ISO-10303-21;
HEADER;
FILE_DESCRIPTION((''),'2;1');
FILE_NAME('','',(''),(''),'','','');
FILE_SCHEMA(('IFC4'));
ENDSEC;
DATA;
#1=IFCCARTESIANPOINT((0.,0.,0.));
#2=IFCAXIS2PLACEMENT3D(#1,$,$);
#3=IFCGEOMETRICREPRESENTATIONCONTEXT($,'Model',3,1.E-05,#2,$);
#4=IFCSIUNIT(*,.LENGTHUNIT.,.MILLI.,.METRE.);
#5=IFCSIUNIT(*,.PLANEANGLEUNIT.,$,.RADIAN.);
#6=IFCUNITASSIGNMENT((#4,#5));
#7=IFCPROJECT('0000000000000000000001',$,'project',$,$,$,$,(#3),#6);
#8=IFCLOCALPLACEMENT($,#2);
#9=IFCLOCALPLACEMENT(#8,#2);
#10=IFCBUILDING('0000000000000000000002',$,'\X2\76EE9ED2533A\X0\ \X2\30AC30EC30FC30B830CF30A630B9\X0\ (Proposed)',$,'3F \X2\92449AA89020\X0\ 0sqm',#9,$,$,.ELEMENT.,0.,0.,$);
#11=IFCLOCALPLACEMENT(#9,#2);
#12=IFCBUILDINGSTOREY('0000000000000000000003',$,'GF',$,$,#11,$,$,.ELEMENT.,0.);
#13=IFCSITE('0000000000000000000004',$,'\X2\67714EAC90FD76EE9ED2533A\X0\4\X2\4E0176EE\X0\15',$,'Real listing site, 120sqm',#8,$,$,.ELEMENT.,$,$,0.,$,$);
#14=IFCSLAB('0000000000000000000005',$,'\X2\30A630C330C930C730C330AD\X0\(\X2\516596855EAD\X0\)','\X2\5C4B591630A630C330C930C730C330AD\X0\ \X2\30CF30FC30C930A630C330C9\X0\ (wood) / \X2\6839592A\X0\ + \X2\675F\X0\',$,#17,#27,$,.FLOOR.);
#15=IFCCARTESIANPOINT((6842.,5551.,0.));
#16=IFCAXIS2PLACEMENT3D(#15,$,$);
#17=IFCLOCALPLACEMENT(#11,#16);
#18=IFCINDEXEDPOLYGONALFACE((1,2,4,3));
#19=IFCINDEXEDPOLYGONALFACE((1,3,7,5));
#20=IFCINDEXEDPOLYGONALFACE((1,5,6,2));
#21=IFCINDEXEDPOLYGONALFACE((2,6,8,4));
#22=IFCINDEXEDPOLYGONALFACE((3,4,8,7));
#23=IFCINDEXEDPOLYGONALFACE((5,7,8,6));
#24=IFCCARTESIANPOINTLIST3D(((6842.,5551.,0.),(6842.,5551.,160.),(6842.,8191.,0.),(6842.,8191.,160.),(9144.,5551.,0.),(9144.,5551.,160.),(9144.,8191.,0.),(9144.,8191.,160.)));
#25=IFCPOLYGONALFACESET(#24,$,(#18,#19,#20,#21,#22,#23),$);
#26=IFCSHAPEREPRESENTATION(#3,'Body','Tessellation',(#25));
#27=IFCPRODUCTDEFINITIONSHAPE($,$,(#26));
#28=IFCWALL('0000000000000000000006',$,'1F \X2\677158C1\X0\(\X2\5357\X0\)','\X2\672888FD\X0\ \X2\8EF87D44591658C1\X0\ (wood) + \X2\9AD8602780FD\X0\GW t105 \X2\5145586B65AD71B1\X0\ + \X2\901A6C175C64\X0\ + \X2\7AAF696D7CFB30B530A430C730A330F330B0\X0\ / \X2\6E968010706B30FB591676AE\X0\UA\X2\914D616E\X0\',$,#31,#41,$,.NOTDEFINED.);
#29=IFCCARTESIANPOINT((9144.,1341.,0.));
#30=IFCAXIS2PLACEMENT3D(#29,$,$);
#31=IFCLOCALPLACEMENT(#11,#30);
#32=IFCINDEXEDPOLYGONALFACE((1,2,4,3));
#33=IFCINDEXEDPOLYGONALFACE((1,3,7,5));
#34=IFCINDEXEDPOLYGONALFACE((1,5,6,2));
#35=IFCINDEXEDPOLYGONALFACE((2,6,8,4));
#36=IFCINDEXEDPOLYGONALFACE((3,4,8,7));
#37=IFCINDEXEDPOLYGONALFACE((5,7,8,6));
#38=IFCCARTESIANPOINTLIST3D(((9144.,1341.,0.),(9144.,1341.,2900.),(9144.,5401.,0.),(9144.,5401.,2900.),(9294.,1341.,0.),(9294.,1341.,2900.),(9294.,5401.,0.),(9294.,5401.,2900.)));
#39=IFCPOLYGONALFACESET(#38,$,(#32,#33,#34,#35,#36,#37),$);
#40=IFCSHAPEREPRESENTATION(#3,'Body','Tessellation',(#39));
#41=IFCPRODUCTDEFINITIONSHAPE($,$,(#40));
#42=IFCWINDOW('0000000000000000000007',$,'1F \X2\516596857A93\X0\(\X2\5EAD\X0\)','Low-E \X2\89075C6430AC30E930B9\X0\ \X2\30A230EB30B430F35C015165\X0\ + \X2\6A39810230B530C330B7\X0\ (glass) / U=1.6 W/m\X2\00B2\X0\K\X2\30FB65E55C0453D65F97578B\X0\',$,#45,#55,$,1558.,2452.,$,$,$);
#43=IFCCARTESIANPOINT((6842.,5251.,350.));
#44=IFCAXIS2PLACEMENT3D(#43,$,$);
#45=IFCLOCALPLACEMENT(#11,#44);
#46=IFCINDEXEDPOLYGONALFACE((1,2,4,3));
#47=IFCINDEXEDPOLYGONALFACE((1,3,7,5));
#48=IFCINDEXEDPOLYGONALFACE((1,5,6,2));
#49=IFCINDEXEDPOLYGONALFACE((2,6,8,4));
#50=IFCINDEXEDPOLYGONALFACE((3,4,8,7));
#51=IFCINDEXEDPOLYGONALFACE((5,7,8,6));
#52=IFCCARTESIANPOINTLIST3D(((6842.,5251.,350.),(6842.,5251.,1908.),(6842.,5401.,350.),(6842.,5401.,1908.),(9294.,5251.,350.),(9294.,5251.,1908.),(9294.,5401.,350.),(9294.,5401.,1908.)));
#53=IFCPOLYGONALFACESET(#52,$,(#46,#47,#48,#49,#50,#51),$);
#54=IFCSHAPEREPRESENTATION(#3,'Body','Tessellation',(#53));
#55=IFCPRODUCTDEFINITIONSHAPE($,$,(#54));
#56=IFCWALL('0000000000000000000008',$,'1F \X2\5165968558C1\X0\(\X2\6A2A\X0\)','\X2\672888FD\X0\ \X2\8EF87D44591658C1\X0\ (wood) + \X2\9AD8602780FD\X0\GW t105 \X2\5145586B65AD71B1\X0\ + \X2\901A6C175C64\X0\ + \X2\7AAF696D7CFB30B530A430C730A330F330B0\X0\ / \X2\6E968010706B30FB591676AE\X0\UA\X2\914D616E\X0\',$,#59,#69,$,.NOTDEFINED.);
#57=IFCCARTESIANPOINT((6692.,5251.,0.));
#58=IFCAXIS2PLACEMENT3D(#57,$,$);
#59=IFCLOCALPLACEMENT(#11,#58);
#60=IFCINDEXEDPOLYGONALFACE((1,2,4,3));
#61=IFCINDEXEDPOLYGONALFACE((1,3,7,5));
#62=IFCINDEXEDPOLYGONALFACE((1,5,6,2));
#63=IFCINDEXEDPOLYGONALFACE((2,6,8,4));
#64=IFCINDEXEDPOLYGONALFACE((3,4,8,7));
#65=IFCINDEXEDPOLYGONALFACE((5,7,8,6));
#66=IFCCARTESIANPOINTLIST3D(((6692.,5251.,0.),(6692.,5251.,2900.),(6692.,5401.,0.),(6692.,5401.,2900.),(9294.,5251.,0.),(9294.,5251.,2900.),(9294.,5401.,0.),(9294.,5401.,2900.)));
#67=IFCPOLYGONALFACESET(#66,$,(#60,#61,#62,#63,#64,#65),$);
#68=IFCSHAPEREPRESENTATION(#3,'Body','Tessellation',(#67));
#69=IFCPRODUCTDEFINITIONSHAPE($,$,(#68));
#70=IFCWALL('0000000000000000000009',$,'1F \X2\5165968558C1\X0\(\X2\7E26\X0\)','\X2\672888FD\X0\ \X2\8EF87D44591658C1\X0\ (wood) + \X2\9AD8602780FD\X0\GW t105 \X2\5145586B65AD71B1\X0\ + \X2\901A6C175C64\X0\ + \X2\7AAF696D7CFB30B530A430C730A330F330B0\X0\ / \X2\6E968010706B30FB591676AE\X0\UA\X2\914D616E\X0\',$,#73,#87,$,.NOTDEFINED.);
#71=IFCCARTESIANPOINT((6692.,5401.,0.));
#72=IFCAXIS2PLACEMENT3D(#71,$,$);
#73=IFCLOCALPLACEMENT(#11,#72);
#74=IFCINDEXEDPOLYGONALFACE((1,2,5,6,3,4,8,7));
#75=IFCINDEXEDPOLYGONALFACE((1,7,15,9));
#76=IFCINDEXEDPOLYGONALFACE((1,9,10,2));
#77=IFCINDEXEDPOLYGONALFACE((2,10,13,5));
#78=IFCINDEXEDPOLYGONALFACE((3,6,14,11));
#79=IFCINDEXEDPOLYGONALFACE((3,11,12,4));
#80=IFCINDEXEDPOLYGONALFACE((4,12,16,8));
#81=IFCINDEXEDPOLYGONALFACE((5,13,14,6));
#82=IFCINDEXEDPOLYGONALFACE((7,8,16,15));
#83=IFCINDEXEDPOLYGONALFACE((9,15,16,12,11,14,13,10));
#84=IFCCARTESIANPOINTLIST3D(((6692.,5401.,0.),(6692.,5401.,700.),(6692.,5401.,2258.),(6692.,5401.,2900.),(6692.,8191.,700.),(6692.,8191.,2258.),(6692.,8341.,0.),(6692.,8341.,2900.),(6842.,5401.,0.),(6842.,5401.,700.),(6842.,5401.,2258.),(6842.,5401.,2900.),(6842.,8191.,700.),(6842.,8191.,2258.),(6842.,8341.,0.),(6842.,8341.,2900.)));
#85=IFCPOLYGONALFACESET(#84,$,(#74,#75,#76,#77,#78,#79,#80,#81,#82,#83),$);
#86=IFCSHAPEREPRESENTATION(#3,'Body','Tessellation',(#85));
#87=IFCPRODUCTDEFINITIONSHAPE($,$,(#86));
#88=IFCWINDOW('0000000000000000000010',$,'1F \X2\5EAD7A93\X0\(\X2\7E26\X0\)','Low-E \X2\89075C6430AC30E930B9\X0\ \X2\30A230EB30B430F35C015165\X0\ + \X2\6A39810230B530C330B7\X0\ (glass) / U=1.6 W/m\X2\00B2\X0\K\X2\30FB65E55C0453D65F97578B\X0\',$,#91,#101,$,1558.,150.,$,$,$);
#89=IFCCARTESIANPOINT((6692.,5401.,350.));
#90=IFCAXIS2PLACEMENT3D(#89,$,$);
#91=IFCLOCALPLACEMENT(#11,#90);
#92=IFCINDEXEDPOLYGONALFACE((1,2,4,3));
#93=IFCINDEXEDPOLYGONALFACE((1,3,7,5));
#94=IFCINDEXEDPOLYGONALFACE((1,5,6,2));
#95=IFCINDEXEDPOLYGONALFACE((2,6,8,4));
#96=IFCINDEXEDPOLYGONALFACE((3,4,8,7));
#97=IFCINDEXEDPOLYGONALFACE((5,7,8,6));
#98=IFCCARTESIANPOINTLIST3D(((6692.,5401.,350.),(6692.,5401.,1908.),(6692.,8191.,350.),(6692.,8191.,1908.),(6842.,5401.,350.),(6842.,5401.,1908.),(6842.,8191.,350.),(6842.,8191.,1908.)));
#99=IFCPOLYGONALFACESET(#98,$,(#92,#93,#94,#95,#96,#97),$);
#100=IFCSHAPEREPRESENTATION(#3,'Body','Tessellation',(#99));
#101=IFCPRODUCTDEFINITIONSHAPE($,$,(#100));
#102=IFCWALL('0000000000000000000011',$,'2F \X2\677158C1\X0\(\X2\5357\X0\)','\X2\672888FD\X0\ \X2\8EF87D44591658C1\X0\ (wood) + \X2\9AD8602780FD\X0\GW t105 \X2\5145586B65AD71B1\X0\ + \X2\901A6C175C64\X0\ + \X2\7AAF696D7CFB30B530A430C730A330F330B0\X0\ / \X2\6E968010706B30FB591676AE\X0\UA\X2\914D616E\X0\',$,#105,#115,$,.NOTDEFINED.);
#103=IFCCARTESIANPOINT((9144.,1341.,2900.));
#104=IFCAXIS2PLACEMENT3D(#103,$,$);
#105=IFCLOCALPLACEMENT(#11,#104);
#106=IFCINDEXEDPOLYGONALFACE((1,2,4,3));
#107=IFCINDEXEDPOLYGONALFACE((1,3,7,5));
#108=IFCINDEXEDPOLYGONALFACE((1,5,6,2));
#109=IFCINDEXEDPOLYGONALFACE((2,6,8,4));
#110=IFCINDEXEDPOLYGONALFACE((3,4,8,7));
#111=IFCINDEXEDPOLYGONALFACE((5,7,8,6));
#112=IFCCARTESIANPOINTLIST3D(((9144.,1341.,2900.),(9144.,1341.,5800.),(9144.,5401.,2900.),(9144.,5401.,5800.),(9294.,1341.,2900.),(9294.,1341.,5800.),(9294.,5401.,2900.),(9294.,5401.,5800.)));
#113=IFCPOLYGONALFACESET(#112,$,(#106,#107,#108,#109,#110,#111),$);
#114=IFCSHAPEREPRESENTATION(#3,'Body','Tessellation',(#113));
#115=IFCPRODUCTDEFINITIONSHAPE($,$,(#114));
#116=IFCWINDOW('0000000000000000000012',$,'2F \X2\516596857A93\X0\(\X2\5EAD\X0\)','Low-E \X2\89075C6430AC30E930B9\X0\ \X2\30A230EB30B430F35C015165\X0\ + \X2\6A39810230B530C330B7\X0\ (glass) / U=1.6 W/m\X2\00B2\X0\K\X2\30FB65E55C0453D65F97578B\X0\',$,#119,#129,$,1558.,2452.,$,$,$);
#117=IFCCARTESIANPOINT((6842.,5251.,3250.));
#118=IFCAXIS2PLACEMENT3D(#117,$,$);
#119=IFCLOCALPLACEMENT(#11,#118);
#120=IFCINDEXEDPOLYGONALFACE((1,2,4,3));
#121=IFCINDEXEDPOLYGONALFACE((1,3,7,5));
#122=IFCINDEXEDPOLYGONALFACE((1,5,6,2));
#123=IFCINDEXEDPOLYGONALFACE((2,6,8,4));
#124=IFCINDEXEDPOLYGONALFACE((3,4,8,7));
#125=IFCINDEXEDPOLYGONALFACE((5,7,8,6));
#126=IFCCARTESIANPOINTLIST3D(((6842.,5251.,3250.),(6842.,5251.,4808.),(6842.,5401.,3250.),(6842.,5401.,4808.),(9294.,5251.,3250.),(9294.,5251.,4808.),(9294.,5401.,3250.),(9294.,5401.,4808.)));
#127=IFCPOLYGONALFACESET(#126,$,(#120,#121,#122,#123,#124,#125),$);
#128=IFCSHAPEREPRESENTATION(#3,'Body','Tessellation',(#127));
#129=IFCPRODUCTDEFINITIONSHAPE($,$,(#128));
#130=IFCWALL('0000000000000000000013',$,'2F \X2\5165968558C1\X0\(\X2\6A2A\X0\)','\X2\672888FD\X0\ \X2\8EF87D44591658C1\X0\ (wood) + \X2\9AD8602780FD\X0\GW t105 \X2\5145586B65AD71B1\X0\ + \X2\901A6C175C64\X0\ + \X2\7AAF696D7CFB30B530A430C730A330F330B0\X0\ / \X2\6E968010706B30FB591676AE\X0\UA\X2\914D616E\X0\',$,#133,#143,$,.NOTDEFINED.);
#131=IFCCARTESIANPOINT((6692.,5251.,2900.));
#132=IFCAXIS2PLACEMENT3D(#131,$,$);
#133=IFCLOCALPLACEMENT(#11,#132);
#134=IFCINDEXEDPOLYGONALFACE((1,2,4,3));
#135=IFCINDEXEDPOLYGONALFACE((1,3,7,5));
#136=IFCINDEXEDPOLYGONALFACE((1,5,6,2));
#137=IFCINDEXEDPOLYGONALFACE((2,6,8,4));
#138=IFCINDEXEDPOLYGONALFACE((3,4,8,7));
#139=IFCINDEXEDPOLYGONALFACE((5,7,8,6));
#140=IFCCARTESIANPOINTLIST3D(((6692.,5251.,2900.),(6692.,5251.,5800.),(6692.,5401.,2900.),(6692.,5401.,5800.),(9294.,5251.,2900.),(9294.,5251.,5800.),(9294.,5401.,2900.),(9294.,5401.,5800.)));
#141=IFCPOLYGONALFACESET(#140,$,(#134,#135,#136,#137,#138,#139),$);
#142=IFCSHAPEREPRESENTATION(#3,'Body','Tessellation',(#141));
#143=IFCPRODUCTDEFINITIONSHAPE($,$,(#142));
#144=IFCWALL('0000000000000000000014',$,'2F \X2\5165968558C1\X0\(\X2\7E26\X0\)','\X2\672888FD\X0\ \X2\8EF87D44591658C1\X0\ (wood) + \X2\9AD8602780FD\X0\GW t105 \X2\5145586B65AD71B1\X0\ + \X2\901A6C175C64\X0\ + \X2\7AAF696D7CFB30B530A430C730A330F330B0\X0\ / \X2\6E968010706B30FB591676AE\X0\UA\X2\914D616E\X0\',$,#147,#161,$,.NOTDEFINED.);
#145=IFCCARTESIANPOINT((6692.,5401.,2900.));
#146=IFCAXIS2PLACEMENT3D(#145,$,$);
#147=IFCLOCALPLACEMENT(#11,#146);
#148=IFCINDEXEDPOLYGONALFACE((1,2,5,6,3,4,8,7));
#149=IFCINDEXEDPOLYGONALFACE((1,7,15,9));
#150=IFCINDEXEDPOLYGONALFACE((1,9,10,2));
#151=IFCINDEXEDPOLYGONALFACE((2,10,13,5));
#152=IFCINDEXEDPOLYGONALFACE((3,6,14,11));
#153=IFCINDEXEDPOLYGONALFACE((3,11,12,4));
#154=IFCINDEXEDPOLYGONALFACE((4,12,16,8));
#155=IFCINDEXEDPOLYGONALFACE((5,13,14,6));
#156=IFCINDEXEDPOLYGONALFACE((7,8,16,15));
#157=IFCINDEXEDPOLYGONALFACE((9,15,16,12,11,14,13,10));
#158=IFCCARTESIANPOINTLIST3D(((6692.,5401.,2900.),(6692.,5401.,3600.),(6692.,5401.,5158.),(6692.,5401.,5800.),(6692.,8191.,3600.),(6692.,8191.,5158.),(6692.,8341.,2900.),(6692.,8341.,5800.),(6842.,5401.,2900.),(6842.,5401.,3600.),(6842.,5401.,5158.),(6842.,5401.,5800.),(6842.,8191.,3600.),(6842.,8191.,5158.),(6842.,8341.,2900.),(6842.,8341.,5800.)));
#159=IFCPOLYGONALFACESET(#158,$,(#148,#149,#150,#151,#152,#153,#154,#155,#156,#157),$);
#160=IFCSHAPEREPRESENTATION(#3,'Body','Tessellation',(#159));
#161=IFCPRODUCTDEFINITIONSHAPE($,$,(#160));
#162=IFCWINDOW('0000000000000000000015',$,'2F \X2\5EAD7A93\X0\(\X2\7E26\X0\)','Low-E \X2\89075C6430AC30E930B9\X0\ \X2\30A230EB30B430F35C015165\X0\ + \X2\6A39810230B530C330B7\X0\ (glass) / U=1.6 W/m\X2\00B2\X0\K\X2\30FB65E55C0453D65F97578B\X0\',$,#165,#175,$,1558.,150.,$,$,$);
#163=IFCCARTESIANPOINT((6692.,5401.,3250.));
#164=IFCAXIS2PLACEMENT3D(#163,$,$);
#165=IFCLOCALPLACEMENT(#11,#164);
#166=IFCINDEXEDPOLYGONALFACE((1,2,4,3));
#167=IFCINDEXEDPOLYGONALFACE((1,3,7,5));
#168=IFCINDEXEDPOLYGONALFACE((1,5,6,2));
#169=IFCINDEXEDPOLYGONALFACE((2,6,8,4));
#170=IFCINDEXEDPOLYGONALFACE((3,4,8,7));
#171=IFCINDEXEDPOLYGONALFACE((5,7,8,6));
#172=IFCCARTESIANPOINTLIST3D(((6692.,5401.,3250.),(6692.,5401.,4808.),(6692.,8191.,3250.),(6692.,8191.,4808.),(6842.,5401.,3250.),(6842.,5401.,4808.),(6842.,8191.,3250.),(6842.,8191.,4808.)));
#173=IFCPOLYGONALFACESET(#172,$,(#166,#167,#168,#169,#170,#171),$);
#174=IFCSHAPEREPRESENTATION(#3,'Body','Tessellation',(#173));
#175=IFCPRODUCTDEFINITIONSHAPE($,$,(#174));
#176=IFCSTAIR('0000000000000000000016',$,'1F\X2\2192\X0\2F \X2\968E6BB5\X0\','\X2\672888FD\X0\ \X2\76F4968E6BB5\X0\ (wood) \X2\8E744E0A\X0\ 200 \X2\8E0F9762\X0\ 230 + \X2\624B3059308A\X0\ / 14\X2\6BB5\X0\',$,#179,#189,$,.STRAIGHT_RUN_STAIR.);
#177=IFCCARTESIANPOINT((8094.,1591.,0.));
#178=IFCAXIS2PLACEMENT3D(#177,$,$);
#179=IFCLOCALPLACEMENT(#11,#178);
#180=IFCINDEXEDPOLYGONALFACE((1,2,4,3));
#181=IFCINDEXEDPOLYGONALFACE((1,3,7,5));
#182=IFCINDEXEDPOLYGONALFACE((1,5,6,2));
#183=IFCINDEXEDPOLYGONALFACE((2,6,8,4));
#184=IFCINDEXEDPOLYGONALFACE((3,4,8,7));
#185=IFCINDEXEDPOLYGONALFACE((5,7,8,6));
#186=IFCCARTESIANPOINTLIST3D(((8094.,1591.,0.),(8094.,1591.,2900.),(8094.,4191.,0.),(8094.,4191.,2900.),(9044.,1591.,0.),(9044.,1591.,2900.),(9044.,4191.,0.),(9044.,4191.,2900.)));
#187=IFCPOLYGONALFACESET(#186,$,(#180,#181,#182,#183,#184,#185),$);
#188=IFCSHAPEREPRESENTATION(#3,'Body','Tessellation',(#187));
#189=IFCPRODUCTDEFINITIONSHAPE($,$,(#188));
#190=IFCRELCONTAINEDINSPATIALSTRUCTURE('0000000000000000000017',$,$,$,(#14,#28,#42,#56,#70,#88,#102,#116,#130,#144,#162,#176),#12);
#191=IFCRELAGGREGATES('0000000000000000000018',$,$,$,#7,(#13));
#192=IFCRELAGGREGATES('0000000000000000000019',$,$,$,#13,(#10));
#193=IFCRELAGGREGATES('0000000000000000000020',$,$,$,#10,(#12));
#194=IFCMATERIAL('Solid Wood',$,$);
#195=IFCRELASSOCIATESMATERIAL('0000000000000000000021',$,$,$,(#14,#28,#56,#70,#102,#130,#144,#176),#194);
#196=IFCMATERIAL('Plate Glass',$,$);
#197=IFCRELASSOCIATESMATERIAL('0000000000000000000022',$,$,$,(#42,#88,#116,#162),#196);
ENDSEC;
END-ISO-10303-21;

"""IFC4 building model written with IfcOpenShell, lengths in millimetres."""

from ifc_helpers import new_model, si_unit, frame, frame_2d, origin, place, context, project, spatial, rectangle, extrude, material, element, fill, save


model = new_model("IFC4")

# Units and contexts
model_context = context("Model", 3, precision=1e-05, world=origin())
ifc_project = project(units=[si_unit("LENGTHUNIT", "METRE", prefix="MILLI"), si_unit("PLANEANGLEUNIT", "RADIAN")], contexts=[model_context])

# Site, building, storey
site_placement = place(None, origin())
site = spatial("IfcSite", under=ifc_project, at=site_placement, Name="東京都目黒区4丁目15", ObjectType="Real listing site, 120sqm", CompositionType="ELEMENT", RefElevation=0.0)
building_placement = place(site_placement, origin())
building = spatial("IfcBuilding", under=site, at=building_placement, Name="目黒区 ガレージハウス (Proposed)", ObjectType="3F 鉄骨造 0sqm", CompositionType="ELEMENT", ElevationOfRefHeight=0.0, ElevationOfTerrain=0.0)
storey_placement = place(building_placement, origin())
storey = spatial("IfcBuildingStorey", under=building, at=storey_placement, Name="GF", CompositionType="ELEMENT", Elevation=0.0)

# Slab
ifc_material_1 = material(Name="Solid Wood")
slab_placement = place(storey_placement, frame((6842.0, 5551.0, 0.0)))
element("IfcSlab", 1, at=slab_placement, inside=storey, material=ifc_material_1, Name="ウッドデッキ(入隅庭)", Description="屋外ウッドデッキ ハードウッド (wood) / 根太 + 束", PredefinedType="FLOOR", context=model_context, shape_type="SweptSolid", body=[
    extrude(rectangle(XDim=2302.0, YDim=2640.0, at=frame_2d((1151.0, 1320.0))), frame((6842.0, 5551.0, 0.0)), (0.0, 0.0, 1.0), 160.0),
])

# Wall, opening, window
wall_1_placement = place(storey_placement, frame((9144.0, 1341.0, 0.0)))
wall_1 = element("IfcWall", 2, at=wall_1_placement, inside=storey, material=ifc_material_1, Name="1F 東壁(南)", Description="木製 軸組外壁 (wood) + 高性能GW t105 充填断熱 + 通気層 + 窯業系サイディング / 準耐火・外皮UA配慮", PredefinedType="NOTDEFINED", context=model_context, shape_type="SweptSolid", body=[
    extrude(rectangle(XDim=150.0, YDim=4060.0, at=frame_2d((75.0, 2030.0))), frame((9144.0, 1341.0, 0.0)), (0.0, 0.0, 1.0), 2900.0),
])
opening_1_placement = place(storey_placement, frame((6842.0, 5251.0, 350.0)))
opening_1 = element("IfcOpeningElement", 3, at=opening_1_placement, cuts=wall_1, PredefinedType="NOTDEFINED", context=model_context, shape_type="SweptSolid", body=[
    extrude(rectangle(XDim=2452.0, YDim=150.0, at=frame_2d((1226.0, 75.0))), frame((6842.0, 5251.0, 350.0)), (0.0, 0.0, 1.0), 1558.0),
])
ifc_material_2 = material(Name="Plate Glass")
window_1_placement = place(storey_placement, frame((6842.0, 5251.0, 350.0)))
window_1 = element("IfcWindow", 4, at=window_1_placement, inside=storey, material=ifc_material_2, Name="1F 入隅窓(庭)", Description="Low-E 複層ガラス アルゴン封入 + 樹脂サッシ (glass) / U=1.6 W/m²K・日射取得型", OverallHeight=1558.0, OverallWidth=2452.0, context=model_context, shape_type="SweptSolid", body=[
    extrude(rectangle(XDim=2452.0, YDim=150.0, at=frame_2d((1226.0, 75.0))), frame((6842.0, 5251.0, 350.0)), (0.0, 0.0, 1.0), 1558.0),
])
fill(opening_1, window_1)

# Wall
wall_2_placement = place(storey_placement, frame((6692.0, 5251.0, 0.0)))
element("IfcWall", 5, at=wall_2_placement, inside=storey, material=ifc_material_1, Name="1F 入隅壁(横)", Description="木製 軸組外壁 (wood) + 高性能GW t105 充填断熱 + 通気層 + 窯業系サイディング / 準耐火・外皮UA配慮", PredefinedType="NOTDEFINED", context=model_context, shape_type="SweptSolid", body=[
    extrude(rectangle(XDim=2602.0, YDim=150.0, at=frame_2d((1301.0, 75.0))), frame((6692.0, 5251.0, 0.0)), (0.0, 0.0, 1.0), 2900.0),
])

# Wall, opening, window
wall_3_placement = place(storey_placement, frame((6692.0, 5401.0, 0.0)))
wall_3 = element("IfcWall", 6, at=wall_3_placement, inside=storey, material=ifc_material_1, Name="1F 入隅壁(縦)", Description="木製 軸組外壁 (wood) + 高性能GW t105 充填断熱 + 通気層 + 窯業系サイディング / 準耐火・外皮UA配慮", PredefinedType="NOTDEFINED", context=model_context, shape_type="SweptSolid", body=[
    extrude(rectangle(XDim=150.0, YDim=2940.0, at=frame_2d((75.0, 1470.0))), frame((6692.0, 5401.0, 0.0)), (0.0, 0.0, 1.0), 2900.0),
])
opening_2_placement = place(storey_placement, frame((6692.0, 5401.0, 350.0)))
opening_2 = element("IfcOpeningElement", 7, at=opening_2_placement, cuts=wall_3, PredefinedType="NOTDEFINED", context=model_context, shape_type="SweptSolid", body=[
    extrude(rectangle(XDim=150.0, YDim=2790.0, at=frame_2d((75.0, 1395.0))), frame((6692.0, 5401.0, 350.0)), (0.0, 0.0, 1.0), 1558.0),
])
window_2_placement = place(storey_placement, frame((6692.0, 5401.0, 350.0)))
window_2 = element("IfcWindow", 8, at=window_2_placement, inside=storey, material=ifc_material_2, Name="1F 庭窓(縦)", Description="Low-E 複層ガラス アルゴン封入 + 樹脂サッシ (glass) / U=1.6 W/m²K・日射取得型", OverallHeight=1558.0, OverallWidth=150.0, context=model_context, shape_type="SweptSolid", body=[
    extrude(rectangle(XDim=150.0, YDim=2790.0, at=frame_2d((75.0, 1395.0))), frame((6692.0, 5401.0, 350.0)), (0.0, 0.0, 1.0), 1558.0),
])
fill(opening_2, window_2)

# Wall, opening, window
wall_4_placement = place(storey_placement, frame((9144.0, 1341.0, 2900.0)))
wall_4 = element("IfcWall", 9, at=wall_4_placement, inside=storey, material=ifc_material_1, Name="2F 東壁(南)", Description="木製 軸組外壁 (wood) + 高性能GW t105 充填断熱 + 通気層 + 窯業系サイディング / 準耐火・外皮UA配慮", PredefinedType="NOTDEFINED", context=model_context, shape_type="SweptSolid", body=[
    extrude(rectangle(XDim=150.0, YDim=4060.0, at=frame_2d((75.0, 2030.0))), frame((9144.0, 1341.0, 2900.0)), (0.0, 0.0, 1.0), 2900.0),
])
opening_3_placement = place(storey_placement, frame((6842.0, 5251.0, 3250.0)))
opening_3 = element("IfcOpeningElement", 10, at=opening_3_placement, cuts=wall_4, PredefinedType="NOTDEFINED", context=model_context, shape_type="SweptSolid", body=[
    extrude(rectangle(XDim=2452.0, YDim=150.0, at=frame_2d((1226.0, 75.0))), frame((6842.0, 5251.0, 3250.0)), (0.0, 0.0, 1.0), 1558.0),
])
window_3_placement = place(storey_placement, frame((6842.0, 5251.0, 3250.0)))
window_3 = element("IfcWindow", 11, at=window_3_placement, inside=storey, material=ifc_material_2, Name="2F 入隅窓(庭)", Description="Low-E 複層ガラス アルゴン封入 + 樹脂サッシ (glass) / U=1.6 W/m²K・日射取得型", OverallHeight=1558.0, OverallWidth=2452.0, context=model_context, shape_type="SweptSolid", body=[
    extrude(rectangle(XDim=2452.0, YDim=150.0, at=frame_2d((1226.0, 75.0))), frame((6842.0, 5251.0, 3250.0)), (0.0, 0.0, 1.0), 1558.0),
])
fill(opening_3, window_3)

# Wall
wall_5_placement = place(storey_placement, frame((6692.0, 5251.0, 2900.0)))
element("IfcWall", 12, at=wall_5_placement, inside=storey, material=ifc_material_1, Name="2F 入隅壁(横)", Description="木製 軸組外壁 (wood) + 高性能GW t105 充填断熱 + 通気層 + 窯業系サイディング / 準耐火・外皮UA配慮", PredefinedType="NOTDEFINED", context=model_context, shape_type="SweptSolid", body=[
    extrude(rectangle(XDim=2602.0, YDim=150.0, at=frame_2d((1301.0, 75.0))), frame((6692.0, 5251.0, 2900.0)), (0.0, 0.0, 1.0), 2900.0),
])

# Wall, opening, window
wall_6_placement = place(storey_placement, frame((6692.0, 5401.0, 2900.0)))
wall_6 = element("IfcWall", 13, at=wall_6_placement, inside=storey, material=ifc_material_1, Name="2F 入隅壁(縦)", Description="木製 軸組外壁 (wood) + 高性能GW t105 充填断熱 + 通気層 + 窯業系サイディング / 準耐火・外皮UA配慮", PredefinedType="NOTDEFINED", context=model_context, shape_type="SweptSolid", body=[
    extrude(rectangle(XDim=150.0, YDim=2940.0, at=frame_2d((75.0, 1470.0))), frame((6692.0, 5401.0, 2900.0)), (0.0, 0.0, 1.0), 2900.0),
])
opening_4_placement = place(storey_placement, frame((6692.0, 5401.0, 3250.0)))
opening_4 = element("IfcOpeningElement", 14, at=opening_4_placement, cuts=wall_6, PredefinedType="NOTDEFINED", context=model_context, shape_type="SweptSolid", body=[
    extrude(rectangle(XDim=150.0, YDim=2790.0, at=frame_2d((75.0, 1395.0))), frame((6692.0, 5401.0, 3250.0)), (0.0, 0.0, 1.0), 1558.0),
])
window_4_placement = place(storey_placement, frame((6692.0, 5401.0, 3250.0)))
window_4 = element("IfcWindow", 15, at=window_4_placement, inside=storey, material=ifc_material_2, Name="2F 庭窓(縦)", Description="Low-E 複層ガラス アルゴン封入 + 樹脂サッシ (glass) / U=1.6 W/m²K・日射取得型", OverallHeight=1558.0, OverallWidth=150.0, context=model_context, shape_type="SweptSolid", body=[
    extrude(rectangle(XDim=150.0, YDim=2790.0, at=frame_2d((75.0, 1395.0))), frame((6692.0, 5401.0, 3250.0)), (0.0, 0.0, 1.0), 1558.0),
])
fill(opening_4, window_4)

# Stair
stair_placement = place(storey_placement, frame((8094.0, 1591.0, 0.0)))
element("IfcStair", 16, at=stair_placement, inside=storey, material=ifc_material_1, Name="1F→2F 階段", Description="木製 直階段 (wood) 蹴上 200 踏面 230 + 手すり / 14段", PredefinedType="STRAIGHT_RUN_STAIR", context=model_context, shape_type="SweptSolid", body=[
    extrude(rectangle(XDim=950.0, YDim=2600.0, at=frame_2d((475.0, 1300.0))), frame((8094.0, 1591.0, 0.0)), (0.0, 0.0, 1.0), 2900.0),
])

save(model, "model.ifc")
